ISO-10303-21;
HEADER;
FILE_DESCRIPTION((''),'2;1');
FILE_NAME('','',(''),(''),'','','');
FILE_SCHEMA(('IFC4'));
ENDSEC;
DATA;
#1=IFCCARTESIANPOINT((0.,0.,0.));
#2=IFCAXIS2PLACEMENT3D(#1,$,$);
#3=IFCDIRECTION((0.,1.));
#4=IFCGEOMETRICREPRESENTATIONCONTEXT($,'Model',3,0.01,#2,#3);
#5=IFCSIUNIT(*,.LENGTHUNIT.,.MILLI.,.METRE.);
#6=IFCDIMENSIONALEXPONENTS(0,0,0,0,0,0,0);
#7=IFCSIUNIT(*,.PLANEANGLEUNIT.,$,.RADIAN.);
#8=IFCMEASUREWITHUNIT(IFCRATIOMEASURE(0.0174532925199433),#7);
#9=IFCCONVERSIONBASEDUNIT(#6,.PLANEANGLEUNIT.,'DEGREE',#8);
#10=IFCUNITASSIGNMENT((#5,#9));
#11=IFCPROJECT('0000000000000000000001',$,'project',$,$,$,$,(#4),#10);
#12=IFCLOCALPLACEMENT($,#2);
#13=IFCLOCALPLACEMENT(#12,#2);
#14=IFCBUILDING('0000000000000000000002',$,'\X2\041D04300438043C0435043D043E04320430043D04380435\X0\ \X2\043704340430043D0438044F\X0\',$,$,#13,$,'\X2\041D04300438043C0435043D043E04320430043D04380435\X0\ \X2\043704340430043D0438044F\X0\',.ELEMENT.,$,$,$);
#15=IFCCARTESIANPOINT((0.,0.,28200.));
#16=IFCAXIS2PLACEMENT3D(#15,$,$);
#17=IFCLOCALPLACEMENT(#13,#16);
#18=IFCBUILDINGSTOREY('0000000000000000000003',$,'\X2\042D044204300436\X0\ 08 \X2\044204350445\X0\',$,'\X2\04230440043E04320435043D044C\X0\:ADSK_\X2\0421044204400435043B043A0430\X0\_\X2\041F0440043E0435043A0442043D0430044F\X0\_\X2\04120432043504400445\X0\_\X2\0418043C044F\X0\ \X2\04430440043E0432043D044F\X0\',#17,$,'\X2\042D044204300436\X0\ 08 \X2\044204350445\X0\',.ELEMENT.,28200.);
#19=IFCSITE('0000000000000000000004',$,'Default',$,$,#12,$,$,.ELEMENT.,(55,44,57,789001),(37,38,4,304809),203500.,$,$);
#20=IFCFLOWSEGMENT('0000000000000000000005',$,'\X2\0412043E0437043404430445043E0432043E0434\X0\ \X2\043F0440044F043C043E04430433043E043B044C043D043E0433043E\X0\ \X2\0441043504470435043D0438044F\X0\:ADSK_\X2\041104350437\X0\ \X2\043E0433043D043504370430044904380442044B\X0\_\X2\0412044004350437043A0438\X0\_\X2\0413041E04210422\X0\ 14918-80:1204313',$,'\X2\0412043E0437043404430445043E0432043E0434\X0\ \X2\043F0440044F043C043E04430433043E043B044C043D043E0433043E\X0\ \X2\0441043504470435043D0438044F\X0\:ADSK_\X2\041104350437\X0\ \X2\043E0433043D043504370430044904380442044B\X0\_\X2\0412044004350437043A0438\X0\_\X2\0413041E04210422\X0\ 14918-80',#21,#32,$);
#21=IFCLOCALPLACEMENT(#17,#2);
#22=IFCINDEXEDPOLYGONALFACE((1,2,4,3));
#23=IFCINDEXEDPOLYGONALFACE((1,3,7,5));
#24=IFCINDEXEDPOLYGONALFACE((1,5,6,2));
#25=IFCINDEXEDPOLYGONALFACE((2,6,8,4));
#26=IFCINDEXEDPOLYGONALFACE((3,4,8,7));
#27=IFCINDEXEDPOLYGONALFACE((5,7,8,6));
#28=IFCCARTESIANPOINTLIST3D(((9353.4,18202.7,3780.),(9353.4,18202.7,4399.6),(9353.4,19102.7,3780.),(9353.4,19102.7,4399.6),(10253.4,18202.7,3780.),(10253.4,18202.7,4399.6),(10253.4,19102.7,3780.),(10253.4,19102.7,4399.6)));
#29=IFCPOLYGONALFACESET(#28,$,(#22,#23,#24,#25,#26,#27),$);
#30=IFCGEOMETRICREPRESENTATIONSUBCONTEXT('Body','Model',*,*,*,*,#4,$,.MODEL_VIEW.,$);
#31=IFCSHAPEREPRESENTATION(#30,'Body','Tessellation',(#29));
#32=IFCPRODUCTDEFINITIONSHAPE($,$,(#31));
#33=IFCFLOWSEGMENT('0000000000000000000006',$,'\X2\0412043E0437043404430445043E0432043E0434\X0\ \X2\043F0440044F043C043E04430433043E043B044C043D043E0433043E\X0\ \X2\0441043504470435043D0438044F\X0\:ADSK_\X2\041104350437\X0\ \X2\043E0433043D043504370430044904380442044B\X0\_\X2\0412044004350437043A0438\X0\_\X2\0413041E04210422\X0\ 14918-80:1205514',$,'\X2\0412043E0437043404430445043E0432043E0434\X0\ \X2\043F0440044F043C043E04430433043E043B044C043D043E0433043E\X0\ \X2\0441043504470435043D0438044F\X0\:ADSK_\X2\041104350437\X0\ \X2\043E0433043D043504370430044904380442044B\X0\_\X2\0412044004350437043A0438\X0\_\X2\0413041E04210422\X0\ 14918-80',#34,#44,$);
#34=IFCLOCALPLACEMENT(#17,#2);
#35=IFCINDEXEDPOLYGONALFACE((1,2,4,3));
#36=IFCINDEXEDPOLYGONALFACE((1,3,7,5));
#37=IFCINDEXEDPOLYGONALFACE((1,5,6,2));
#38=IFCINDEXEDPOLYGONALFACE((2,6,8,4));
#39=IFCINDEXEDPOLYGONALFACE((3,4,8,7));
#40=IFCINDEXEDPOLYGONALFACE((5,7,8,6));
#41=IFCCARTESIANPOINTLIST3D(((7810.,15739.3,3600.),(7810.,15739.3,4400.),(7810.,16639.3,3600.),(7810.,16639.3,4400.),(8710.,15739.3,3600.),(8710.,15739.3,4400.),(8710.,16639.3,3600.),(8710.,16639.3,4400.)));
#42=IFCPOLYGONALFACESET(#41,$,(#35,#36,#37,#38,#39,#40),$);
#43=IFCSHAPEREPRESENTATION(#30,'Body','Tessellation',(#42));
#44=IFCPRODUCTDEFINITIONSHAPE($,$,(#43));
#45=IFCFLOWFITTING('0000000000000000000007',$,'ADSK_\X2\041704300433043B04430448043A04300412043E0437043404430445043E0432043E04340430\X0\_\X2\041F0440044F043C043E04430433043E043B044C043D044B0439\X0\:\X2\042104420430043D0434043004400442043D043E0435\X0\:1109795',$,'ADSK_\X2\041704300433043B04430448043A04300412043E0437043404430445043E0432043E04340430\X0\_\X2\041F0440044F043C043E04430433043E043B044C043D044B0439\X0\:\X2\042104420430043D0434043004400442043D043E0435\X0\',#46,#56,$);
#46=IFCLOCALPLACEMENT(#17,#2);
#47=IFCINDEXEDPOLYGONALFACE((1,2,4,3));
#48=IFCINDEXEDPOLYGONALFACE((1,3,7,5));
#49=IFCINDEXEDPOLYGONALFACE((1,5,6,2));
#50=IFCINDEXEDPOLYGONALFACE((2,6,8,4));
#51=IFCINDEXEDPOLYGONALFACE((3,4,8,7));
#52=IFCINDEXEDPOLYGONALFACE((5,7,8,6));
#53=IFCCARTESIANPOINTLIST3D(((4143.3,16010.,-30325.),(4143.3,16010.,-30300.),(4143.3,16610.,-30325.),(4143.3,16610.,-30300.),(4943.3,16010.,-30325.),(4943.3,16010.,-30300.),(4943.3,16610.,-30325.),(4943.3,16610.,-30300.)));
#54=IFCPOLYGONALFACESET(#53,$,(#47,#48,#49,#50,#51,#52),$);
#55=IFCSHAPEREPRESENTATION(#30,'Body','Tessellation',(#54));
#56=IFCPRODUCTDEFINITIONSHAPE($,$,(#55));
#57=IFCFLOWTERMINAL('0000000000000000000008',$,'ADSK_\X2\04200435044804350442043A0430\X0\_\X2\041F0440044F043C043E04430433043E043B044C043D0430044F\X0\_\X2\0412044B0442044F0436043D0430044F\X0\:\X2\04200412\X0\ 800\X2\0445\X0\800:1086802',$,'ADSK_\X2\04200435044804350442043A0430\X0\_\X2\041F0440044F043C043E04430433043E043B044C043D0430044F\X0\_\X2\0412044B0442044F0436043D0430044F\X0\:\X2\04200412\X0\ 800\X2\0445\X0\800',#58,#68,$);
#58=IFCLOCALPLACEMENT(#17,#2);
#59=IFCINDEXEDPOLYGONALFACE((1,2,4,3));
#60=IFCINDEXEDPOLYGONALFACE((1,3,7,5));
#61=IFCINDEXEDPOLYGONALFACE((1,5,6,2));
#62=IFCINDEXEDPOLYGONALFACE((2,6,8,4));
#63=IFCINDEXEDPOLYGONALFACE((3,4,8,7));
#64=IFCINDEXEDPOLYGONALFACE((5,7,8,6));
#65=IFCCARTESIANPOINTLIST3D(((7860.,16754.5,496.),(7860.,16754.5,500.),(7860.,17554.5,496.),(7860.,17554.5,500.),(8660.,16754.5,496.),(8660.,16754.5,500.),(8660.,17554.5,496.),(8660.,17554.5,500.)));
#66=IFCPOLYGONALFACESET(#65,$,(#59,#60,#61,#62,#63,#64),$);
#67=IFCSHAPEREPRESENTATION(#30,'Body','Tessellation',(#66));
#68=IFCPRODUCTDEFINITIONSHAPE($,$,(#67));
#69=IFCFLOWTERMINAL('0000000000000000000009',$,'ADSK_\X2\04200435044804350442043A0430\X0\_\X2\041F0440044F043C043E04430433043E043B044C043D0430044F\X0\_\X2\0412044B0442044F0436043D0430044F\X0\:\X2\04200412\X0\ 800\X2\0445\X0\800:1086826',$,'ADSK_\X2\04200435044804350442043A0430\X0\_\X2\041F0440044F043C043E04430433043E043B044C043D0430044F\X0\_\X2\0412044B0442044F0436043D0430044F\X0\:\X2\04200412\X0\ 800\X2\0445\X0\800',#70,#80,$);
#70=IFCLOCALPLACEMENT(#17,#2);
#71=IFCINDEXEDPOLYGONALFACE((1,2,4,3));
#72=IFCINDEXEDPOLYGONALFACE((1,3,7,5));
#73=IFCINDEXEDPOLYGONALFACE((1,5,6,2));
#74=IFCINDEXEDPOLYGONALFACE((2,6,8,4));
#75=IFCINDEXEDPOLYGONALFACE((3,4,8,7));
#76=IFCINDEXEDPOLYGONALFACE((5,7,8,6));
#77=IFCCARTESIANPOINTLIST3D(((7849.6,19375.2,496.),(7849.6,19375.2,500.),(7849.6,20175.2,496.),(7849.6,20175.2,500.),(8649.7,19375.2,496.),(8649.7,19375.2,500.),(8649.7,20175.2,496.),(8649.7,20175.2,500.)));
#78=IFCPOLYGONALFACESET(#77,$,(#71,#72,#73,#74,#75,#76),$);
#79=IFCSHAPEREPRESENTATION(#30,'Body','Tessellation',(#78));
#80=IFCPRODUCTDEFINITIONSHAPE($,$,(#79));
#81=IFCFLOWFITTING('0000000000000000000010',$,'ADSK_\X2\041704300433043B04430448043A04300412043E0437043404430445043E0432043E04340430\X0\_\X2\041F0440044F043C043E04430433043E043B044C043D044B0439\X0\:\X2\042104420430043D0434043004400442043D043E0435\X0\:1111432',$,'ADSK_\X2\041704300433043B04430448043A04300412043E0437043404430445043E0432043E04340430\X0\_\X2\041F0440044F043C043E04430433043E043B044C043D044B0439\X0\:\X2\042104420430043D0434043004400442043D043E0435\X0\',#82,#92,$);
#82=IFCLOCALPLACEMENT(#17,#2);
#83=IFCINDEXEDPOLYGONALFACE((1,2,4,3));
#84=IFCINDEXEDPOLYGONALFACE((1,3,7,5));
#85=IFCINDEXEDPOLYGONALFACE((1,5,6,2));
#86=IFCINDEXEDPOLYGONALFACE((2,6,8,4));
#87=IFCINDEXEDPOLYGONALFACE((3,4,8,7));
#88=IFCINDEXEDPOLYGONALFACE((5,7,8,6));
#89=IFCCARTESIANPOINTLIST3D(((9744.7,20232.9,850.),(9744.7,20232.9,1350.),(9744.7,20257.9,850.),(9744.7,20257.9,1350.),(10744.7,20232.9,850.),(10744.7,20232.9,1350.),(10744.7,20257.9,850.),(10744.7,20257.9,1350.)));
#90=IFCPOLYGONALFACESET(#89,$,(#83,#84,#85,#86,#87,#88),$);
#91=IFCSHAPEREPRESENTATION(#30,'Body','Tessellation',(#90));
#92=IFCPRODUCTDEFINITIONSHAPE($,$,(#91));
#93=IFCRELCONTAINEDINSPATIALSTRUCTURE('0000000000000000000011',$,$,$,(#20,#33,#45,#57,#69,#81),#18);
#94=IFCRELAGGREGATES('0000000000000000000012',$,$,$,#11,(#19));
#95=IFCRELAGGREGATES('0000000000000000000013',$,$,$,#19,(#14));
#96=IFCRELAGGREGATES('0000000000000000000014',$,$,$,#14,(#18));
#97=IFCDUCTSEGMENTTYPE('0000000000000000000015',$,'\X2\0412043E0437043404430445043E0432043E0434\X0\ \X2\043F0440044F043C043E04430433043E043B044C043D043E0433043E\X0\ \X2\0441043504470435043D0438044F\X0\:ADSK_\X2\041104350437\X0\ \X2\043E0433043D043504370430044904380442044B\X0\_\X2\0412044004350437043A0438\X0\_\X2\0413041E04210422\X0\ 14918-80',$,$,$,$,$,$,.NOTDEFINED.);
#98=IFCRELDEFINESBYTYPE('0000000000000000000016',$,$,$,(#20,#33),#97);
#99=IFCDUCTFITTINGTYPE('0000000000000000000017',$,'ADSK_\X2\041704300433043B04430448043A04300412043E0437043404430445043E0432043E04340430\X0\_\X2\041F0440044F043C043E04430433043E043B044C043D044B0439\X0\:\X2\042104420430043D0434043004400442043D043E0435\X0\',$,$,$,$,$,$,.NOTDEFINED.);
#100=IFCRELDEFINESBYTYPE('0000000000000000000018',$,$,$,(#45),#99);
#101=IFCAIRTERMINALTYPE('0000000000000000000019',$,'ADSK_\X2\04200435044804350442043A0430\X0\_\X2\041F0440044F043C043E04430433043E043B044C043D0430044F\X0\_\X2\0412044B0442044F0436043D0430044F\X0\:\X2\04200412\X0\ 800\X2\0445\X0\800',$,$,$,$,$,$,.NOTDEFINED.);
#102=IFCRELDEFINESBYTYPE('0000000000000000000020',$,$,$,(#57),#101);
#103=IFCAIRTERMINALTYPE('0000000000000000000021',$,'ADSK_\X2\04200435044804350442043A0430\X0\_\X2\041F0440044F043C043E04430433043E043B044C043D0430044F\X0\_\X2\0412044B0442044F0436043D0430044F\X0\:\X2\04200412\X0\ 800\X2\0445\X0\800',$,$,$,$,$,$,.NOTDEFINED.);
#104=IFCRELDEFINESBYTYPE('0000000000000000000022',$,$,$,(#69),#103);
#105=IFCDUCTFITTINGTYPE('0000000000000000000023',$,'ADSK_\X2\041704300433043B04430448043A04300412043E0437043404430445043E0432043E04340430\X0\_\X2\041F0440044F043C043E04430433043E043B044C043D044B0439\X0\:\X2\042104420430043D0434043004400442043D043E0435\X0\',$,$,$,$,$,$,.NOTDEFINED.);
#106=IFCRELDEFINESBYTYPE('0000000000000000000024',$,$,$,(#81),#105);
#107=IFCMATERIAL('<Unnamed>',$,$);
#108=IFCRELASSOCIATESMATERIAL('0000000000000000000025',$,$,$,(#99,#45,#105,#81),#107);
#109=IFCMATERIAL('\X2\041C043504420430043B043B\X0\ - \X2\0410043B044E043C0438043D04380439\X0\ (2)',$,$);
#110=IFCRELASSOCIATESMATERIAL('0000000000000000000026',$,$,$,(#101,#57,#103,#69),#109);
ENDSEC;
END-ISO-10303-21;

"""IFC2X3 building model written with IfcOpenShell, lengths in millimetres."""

from ifc_helpers import new_model, entity, si_unit, converted_unit, direction, frame, origin, origin_2d_with_axis, place, context, subcontext, project, spatial, rectangle, extrude, source, transform, mapped, material, type_object, type_shapes, element, save


model = new_model("IFC2X3")

# Units and contexts
model_context = context("Model", 3, precision=0.01, world=origin(), true_north=direction((0.0, 1.0)))
body_context = subcontext(model_context, "Body", "Model", "MODEL_VIEW")
ifc_project = project(units=[si_unit("LENGTHUNIT", "METRE", prefix="MILLI"), converted_unit("PLANEANGLEUNIT", "DEGREE", entity("IfcRatioMeasure", 0.0174532925199433), si_unit("PLANEANGLEUNIT", "RADIAN"), dimensions=[0, 0, 0, 0, 0, 0, 0])], contexts=[model_context])

# Site, building, storey
site_placement = place(None, origin())
site = spatial("IfcSite", under=ifc_project, at=site_placement, Name="Default", CompositionType="ELEMENT", RefLatitude=(55, 44, 57, 789001), RefLongitude=(37, 38, 4, 304809), RefElevation=203500.0)
building_placement = place(site_placement, origin())
building = spatial("IfcBuilding", under=site, at=building_placement, Name="Наименование здания", LongName="Наименование здания", CompositionType="ELEMENT")
storey_placement = place(building_placement, frame((0.0, 0.0, 28200.0)))
storey = spatial("IfcBuildingStorey", under=building, at=storey_placement, Name="Этаж 08 тех", ObjectType="Уровень:ADSK_Стрелка_Проектная_Вверх_Имя уровня", LongName="Этаж 08 тех", CompositionType="ELEMENT", Elevation=28200.0)

# Flow segments
duct_segment_type_1 = type_object("IfcDuctSegmentType", Name="Воздуховод прямоугольного сечения:ADSK_Без огнезащиты_Врезки_ГОСТ 14918-80", PredefinedType="NOTDEFINED")
flow_segment_1_placement = place(storey_placement, frame((9353.4, 18202.7, 3780.0)))
element("IfcFlowSegment", 1, at=flow_segment_1_placement, inside=storey, type_object=duct_segment_type_1, Name="Воздуховод прямоугольного сечения:ADSK_Без огнезащиты_Врезки_ГОСТ 14918-80:1204313", ObjectType="Воздуховод прямоугольного сечения:ADSK_Без огнезащиты_Врезки_ГОСТ 14918-80", context=body_context, shape_type="SweptSolid", body=[
    extrude(rectangle(XDim=900.0, YDim=900.0, at=origin_2d_with_axis()), frame((450.0, 450.0, 0.0)), (0.0, 0.0, 1.0), 619.6),
])
flow_segment_2_placement = place(storey_placement, frame((7810.0, 15739.3, 3600.0)))
element("IfcFlowSegment", 2, at=flow_segment_2_placement, inside=storey, type_object=duct_segment_type_1, Name="Воздуховод прямоугольного сечения:ADSK_Без огнезащиты_Врезки_ГОСТ 14918-80:1205514", ObjectType="Воздуховод прямоугольного сечения:ADSK_Без огнезащиты_Врезки_ГОСТ 14918-80", context=body_context, shape_type="SweptSolid", body=[
    extrude(rectangle(XDim=900.0, YDim=900.0, at=origin_2d_with_axis()), frame((450.0, 450.0, 0.0)), (0.0, 0.0, 1.0), 800.0),
])

# Flow fitting
ifc_material_1 = material(Name="<Unnamed>")
duct_fitting_type_1 = type_object("IfcDuctFittingType", Name="ADSK_ЗаглушкаВоздуховода_Прямоугольный:Стандартное", PredefinedType="NOTDEFINED", material=ifc_material_1)
shared_shape_1 = source(origin(), body_context, "Body", "SweptSolid", [
    extrude(rectangle(XDim=25.0, YDim=800.0, at=origin_2d_with_axis()), frame((12.5, 0.0, -300.0)), (0.0, 0.0, 1.0), 600.0),
])
type_shapes(duct_fitting_type_1, [shared_shape_1])
flow_fitting_1_placement = place(storey_placement, frame((4543.3, 16310.0, -30300.0), z_axis=(0.0, 1.0, 0.0), x_axis=(0.0, 0.0, -1.0)))
element("IfcFlowFitting", 3, at=flow_fitting_1_placement, inside=storey, type_object=duct_fitting_type_1, material=ifc_material_1, Name="ADSK_ЗаглушкаВоздуховода_Прямоугольный:Стандартное:1109795", ObjectType="ADSK_ЗаглушкаВоздуховода_Прямоугольный:Стандартное", context=body_context, shape_type="MappedRepresentation", body=[
    mapped(shared_shape_1, transform((0.0, 0.0, 0.0), scale=1.0)),
])

# Flow terminals
ifc_material_2 = material(Name="Металл - Алюминий (2)")
air_terminal_type_1 = type_object("IfcAirTerminalType", Name="ADSK_Решетка_Прямоугольная_Вытяжная:РВ 800х800", PredefinedType="NOTDEFINED", material=ifc_material_2)
shared_shape_2 = source(origin(), body_context, "Body", "SweptSolid", [
    extrude(rectangle(XDim=800.0, YDim=4.0, at=origin_2d_with_axis()), frame((0.0, 2.0, -400.0), z_axis=(0.0, 0.0, 1.0), x_axis=(-1.0, 0.0, 0.0)), (0.0, 0.0, 1.0), 800.0),
])
type_shapes(air_terminal_type_1, [shared_shape_2])
flow_terminal_1_placement = place(storey_placement, frame((8260.0, 17154.5, 500.0), z_axis=(0.0, 1.0, 0.0), x_axis=(1.0, 0.0, 0.0)))
element("IfcFlowTerminal", 4, at=flow_terminal_1_placement, inside=storey, type_object=air_terminal_type_1, material=ifc_material_2, Name="ADSK_Решетка_Прямоугольная_Вытяжная:РВ 800х800:1086802", ObjectType="ADSK_Решетка_Прямоугольная_Вытяжная:РВ 800х800", context=body_context, shape_type="MappedRepresentation", body=[
    mapped(shared_shape_2, transform((0.0, 0.0, 0.0), scale=1.0)),
])
air_terminal_type_2 = type_object("IfcAirTerminalType", Name="ADSK_Решетка_Прямоугольная_Вытяжная:РВ 800х800", PredefinedType="NOTDEFINED", material=ifc_material_2)
shared_shape_3 = source(origin(), body_context, "Body", "SweptSolid", [
    extrude(rectangle(XDim=4.0, YDim=800.0, at=origin_2d_with_axis()), frame((0.0, -2.0, -400.0), z_axis=(0.0, 0.0, 1.0), x_axis=(0.0, 1.0, 0.0)), (0.0, 0.0, 1.0), 800.0),
])
type_shapes(air_terminal_type_2, [shared_shape_3])
flow_terminal_2_placement = place(storey_placement, frame((8249.6, 19775.2, 500.0), z_axis=(1.0, 0.0, 0.0), x_axis=(0.0, 1.0, 0.0)))
element("IfcFlowTerminal", 5, at=flow_terminal_2_placement, inside=storey, type_object=air_terminal_type_2, material=ifc_material_2, Name="ADSK_Решетка_Прямоугольная_Вытяжная:РВ 800х800:1086826", ObjectType="ADSK_Решетка_Прямоугольная_Вытяжная:РВ 800х800", context=body_context, shape_type="MappedRepresentation", body=[
    mapped(shared_shape_3, transform((0.0, 0.0, 0.0), scale=1.0)),
])

# Flow fitting
duct_fitting_type_2 = type_object("IfcDuctFittingType", Name="ADSK_ЗаглушкаВоздуховода_Прямоугольный:Стандартное", PredefinedType="NOTDEFINED", material=ifc_material_1)
shared_shape_4 = source(origin(), body_context, "Body", "SweptSolid", [
    extrude(rectangle(XDim=25.0, YDim=500.0, at=origin_2d_with_axis()), frame((12.5, 0.0, -500.0)), (0.0, 0.0, 1.0), 1000.0),
])
type_shapes(duct_fitting_type_2, [shared_shape_4])
flow_fitting_2_placement = place(storey_placement, frame((10244.7, 20232.9, 1100.0), z_axis=(-1.0, 0.0, 0.0), x_axis=(0.0, 1.0, 0.0)))
element("IfcFlowFitting", 6, at=flow_fitting_2_placement, inside=storey, type_object=duct_fitting_type_2, material=ifc_material_1, Name="ADSK_ЗаглушкаВоздуховода_Прямоугольный:Стандартное:1111432", ObjectType="ADSK_ЗаглушкаВоздуховода_Прямоугольный:Стандартное", context=body_context, shape_type="MappedRepresentation", body=[
    mapped(shared_shape_4, transform((0.0, 0.0, 0.0), scale=1.0)),
])

save(model, "model.ifc")
